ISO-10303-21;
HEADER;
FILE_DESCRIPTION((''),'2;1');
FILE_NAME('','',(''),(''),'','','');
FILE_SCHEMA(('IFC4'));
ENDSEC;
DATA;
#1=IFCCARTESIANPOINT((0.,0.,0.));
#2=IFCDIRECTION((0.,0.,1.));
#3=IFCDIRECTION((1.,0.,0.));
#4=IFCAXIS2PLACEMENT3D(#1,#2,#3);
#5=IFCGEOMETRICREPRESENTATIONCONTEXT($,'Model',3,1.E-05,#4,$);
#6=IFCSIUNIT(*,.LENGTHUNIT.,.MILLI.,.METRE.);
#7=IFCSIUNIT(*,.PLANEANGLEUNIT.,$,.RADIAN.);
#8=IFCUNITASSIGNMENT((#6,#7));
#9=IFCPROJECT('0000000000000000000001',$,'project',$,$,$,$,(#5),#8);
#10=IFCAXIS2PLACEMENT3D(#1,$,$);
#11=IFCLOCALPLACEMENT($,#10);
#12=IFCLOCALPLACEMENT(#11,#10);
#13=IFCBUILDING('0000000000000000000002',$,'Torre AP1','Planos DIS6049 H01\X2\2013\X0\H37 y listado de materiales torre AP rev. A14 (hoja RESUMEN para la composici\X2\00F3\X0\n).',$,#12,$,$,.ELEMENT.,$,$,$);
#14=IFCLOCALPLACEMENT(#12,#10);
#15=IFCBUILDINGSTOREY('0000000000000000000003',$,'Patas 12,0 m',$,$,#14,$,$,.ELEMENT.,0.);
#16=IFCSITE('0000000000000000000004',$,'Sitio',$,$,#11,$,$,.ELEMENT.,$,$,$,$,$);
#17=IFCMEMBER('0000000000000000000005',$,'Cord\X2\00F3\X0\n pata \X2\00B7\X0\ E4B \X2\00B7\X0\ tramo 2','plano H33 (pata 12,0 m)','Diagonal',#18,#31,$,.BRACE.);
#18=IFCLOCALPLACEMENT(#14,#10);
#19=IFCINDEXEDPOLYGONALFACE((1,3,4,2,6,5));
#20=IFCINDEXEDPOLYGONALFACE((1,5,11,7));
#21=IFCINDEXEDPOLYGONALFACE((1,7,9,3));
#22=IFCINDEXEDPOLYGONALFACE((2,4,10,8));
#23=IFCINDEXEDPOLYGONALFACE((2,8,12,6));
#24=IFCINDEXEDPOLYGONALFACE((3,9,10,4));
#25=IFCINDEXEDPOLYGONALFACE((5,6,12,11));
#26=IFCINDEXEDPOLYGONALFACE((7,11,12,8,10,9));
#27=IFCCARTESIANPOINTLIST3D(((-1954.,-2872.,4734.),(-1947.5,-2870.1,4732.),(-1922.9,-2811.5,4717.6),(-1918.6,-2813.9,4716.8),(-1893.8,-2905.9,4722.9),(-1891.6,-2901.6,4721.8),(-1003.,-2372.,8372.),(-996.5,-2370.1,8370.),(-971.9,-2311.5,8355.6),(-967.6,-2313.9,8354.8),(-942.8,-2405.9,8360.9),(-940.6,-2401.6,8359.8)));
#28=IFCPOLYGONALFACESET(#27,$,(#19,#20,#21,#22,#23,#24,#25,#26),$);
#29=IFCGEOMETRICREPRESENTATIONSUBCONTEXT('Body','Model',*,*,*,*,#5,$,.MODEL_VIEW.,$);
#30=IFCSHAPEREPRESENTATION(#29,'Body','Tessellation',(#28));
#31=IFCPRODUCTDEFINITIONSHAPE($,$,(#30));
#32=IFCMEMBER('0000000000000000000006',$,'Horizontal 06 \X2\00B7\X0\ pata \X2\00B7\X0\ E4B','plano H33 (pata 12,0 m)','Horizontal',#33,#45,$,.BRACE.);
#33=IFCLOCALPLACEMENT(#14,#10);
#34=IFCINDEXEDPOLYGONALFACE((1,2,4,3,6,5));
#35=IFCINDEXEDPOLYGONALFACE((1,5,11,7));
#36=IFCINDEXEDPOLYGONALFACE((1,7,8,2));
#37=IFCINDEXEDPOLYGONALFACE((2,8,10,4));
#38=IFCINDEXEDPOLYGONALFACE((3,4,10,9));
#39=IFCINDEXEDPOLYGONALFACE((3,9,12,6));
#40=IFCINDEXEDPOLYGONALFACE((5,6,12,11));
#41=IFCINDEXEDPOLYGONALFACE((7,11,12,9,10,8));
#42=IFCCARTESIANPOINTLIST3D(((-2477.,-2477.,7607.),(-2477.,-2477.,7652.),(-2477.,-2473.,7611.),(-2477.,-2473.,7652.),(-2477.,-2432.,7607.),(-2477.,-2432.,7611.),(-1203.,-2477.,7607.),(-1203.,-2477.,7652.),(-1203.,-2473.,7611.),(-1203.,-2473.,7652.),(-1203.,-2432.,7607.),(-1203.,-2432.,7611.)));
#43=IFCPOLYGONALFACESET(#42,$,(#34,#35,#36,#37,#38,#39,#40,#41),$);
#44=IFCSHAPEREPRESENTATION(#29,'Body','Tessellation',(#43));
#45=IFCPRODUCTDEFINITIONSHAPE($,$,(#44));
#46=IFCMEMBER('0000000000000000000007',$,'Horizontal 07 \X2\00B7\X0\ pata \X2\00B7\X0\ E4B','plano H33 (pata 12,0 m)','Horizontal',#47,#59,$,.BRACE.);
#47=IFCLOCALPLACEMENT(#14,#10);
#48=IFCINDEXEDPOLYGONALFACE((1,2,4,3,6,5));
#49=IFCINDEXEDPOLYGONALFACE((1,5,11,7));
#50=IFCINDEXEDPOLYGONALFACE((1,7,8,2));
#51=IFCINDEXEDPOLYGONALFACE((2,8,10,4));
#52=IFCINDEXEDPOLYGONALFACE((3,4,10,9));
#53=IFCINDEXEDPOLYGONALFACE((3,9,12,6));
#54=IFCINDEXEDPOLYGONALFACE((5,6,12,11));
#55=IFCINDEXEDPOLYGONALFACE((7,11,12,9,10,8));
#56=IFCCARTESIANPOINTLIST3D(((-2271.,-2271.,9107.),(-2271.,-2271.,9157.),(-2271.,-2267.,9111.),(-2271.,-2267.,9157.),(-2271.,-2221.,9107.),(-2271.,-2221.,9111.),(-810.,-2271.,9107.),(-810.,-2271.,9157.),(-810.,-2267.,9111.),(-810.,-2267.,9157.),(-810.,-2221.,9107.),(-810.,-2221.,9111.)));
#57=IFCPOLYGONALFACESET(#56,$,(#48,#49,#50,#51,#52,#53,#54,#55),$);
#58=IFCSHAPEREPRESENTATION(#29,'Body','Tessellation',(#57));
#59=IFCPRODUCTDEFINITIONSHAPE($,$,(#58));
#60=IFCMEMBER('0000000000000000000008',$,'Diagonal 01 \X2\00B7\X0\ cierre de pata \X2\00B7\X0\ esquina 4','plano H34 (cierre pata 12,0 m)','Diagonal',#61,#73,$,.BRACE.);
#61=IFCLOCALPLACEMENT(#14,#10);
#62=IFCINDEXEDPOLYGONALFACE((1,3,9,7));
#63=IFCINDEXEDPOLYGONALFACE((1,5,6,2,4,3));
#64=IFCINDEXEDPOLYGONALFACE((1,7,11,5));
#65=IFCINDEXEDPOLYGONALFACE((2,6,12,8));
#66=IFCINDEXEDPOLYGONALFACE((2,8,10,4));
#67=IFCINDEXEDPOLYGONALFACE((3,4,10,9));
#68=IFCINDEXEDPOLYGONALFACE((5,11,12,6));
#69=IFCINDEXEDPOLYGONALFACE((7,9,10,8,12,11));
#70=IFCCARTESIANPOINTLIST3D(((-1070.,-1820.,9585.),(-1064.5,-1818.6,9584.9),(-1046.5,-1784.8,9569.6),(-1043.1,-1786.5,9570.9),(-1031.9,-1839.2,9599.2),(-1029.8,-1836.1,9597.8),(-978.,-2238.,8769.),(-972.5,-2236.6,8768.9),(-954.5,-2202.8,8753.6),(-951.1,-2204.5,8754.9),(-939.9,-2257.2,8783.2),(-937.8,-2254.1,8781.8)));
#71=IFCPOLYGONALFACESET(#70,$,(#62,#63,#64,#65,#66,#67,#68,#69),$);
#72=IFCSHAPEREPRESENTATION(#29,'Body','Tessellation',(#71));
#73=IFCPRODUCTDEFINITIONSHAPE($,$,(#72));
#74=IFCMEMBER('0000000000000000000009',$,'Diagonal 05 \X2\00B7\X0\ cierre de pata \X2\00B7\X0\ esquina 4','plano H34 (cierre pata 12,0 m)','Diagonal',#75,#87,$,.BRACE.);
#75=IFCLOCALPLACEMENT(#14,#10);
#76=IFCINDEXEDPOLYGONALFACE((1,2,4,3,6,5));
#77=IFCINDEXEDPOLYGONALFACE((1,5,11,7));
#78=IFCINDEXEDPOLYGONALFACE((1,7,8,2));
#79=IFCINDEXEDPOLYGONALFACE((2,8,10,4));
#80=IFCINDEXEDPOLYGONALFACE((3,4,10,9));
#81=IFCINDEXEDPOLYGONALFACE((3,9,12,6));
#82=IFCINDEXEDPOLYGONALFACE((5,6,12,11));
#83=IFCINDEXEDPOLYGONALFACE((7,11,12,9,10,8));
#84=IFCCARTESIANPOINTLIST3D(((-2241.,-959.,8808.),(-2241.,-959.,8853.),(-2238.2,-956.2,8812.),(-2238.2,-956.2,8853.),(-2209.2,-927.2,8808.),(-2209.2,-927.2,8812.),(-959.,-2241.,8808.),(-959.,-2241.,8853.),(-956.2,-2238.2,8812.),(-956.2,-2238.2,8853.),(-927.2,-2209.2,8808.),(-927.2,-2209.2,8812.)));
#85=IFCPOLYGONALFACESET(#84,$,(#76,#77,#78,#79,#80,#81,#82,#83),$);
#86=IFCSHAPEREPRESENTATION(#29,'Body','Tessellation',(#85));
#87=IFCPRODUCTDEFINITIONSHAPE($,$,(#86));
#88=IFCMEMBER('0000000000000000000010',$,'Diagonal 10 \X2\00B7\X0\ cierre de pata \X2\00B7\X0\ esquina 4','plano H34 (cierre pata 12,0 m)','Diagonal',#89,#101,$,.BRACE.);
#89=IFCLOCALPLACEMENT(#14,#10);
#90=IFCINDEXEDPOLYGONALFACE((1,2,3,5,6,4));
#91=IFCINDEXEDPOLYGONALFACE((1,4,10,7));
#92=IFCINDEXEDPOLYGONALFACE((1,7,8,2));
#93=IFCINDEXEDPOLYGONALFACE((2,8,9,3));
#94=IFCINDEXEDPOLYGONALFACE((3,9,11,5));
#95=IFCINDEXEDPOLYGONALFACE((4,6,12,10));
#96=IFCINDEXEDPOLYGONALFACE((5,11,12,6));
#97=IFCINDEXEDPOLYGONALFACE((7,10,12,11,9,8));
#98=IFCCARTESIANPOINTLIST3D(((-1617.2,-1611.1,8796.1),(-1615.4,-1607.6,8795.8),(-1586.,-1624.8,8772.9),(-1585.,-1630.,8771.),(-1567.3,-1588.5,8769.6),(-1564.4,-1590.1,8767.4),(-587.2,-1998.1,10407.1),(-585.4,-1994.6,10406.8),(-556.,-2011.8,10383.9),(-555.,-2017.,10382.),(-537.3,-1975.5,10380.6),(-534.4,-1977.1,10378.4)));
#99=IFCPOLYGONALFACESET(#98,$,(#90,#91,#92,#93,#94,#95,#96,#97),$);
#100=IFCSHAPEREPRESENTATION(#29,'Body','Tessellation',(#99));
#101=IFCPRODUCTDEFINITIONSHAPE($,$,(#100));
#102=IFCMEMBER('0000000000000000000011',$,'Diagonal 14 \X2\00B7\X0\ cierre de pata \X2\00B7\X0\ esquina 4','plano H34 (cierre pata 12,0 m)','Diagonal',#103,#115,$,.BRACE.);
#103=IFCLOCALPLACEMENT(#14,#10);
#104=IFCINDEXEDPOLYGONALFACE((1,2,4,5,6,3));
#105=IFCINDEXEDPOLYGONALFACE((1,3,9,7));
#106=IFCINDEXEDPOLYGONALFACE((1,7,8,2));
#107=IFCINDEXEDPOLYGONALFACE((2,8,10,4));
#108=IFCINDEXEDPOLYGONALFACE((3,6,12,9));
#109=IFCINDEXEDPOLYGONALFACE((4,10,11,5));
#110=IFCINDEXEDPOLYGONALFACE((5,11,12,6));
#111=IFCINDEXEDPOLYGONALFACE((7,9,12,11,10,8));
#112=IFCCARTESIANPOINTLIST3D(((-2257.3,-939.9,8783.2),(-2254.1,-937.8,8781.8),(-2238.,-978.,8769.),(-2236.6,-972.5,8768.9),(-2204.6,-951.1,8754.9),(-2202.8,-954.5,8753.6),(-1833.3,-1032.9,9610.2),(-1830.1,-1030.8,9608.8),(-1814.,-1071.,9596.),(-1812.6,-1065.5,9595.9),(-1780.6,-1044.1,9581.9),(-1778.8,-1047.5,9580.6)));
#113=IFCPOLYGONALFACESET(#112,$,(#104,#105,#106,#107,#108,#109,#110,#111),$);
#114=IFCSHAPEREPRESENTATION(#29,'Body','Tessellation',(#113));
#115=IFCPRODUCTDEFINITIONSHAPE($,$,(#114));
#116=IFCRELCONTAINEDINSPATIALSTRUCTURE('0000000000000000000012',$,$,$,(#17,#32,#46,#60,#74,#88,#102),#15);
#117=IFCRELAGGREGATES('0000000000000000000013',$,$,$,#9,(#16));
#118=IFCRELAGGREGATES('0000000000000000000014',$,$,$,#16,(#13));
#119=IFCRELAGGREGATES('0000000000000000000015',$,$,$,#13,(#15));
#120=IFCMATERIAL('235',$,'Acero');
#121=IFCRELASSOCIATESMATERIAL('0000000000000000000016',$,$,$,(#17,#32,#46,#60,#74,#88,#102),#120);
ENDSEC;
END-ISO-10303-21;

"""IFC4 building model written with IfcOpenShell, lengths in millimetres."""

from ifc_helpers import new_model, si_unit, frame, frame_2d, origin, origin_with_axes, place, context, subcontext, project, spatial, l_section, extrude, material, element, save


model = new_model("IFC4")

# Units and contexts
model_context = context("Model", 3, precision=1e-05, world=origin_with_axes())
body_context = subcontext(model_context, "Body", "Model", "MODEL_VIEW")
ifc_project = project(units=[si_unit("LENGTHUNIT", "METRE", prefix="MILLI"), si_unit("PLANEANGLEUNIT", "RADIAN")], contexts=[model_context])

# Site, building, storey
site_placement = place(None, origin())
site = spatial("IfcSite", under=ifc_project, at=site_placement, Name="Sitio", CompositionType="ELEMENT")
building_placement = place(site_placement, origin())
building = spatial("IfcBuilding", under=site, at=building_placement, Name="Torre AP1", Description="Planos DIS6049 H01–H37 y listado de materiales torre AP rev. A14 (hoja RESUMEN para la composición).", CompositionType="ELEMENT")
storey_placement = place(building_placement, origin())
storey = spatial("IfcBuildingStorey", under=building, at=storey_placement, Name="Patas 12,0 m", CompositionType="ELEMENT", Elevation=0.0)

# Members
ifc_material_1 = material(Name="235", Category="Acero")
member_1_placement = place(storey_placement, frame((-1003.0, -2372.0, 8372.0), z_axis=(-0.250702, -0.13181, -0.959049), x_axis=(0.444282, 0.864528, -0.234958)))
element("IfcMember", 1, at=member_1_placement, inside=storey, material=ifc_material_1, Name="Cordón pata · E4B · tramo 2", Description="plano H33 (pata 12,0 m)", ObjectType="Diagonal", PredefinedType="BRACE", context=body_context, shape_type="SweptSolid", body=[
    extrude(l_section(Depth=70.0, Width=70.0, Thickness=5.0, at=frame_2d((35.0, 35.0))), None, (0.0, 0.0, 1.0), 3793.3),
])
member_2_placement = place(storey_placement, frame((-2477.0, -2477.0, 7607.0), z_axis=(1.0, 0.0, 0.0), x_axis=(0.0, 1.0, 0.0)))
element("IfcMember", 2, at=member_2_placement, inside=storey, material=ifc_material_1, Name="Horizontal 06 · pata · E4B", Description="plano H33 (pata 12,0 m)", ObjectType="Horizontal", PredefinedType="BRACE", context=body_context, shape_type="SweptSolid", body=[
    extrude(l_section(Depth=45.0, Width=45.0, Thickness=4.0, at=frame_2d((22.5, 22.5))), None, (0.0, 0.0, 1.0), 1274.0),
])
member_3_placement = place(storey_placement, frame((-2271.0, -2271.0, 9107.0), z_axis=(1.0, 0.0, 0.0), x_axis=(0.0, 1.0, 0.0)))
element("IfcMember", 3, at=member_3_placement, inside=storey, material=ifc_material_1, Name="Horizontal 07 · pata · E4B", Description="plano H33 (pata 12,0 m)", ObjectType="Horizontal", PredefinedType="BRACE", context=body_context, shape_type="SweptSolid", body=[
    extrude(l_section(Depth=50.0, Width=50.0, Thickness=4.0, at=frame_2d((25.0, 25.0))), None, (0.0, 0.0, 1.0), 1461.0),
])
member_4_placement = place(storey_placement, frame((-1070.0, -1820.0, 9585.0), z_axis=(0.099844, -0.45364, -0.885574), x_axis=(0.521462, 0.78186, -0.34172)))
element("IfcMember", 4, at=member_4_placement, inside=storey, material=ifc_material_1, Name="Diagonal 01 · cierre de pata · esquina 4", Description="plano H34 (cierre pata 12,0 m)", ObjectType="Diagonal", PredefinedType="BRACE", context=body_context, shape_type="SweptSolid", body=[
    extrude(l_section(Depth=45.0, Width=45.0, Thickness=4.0, at=frame_2d((22.5, 22.5))), None, (0.0, 0.0, 1.0), 921.4),
])
member_5_placement = place(storey_placement, frame((-2241.0, -959.0, 8808.0), z_axis=(0.707107, -0.707107, 0.0), x_axis=(0.707107, 0.707107, 0.0)))
element("IfcMember", 5, at=member_5_placement, inside=storey, material=ifc_material_1, Name="Diagonal 05 · cierre de pata · esquina 4", Description="plano H34 (cierre pata 12,0 m)", ObjectType="Diagonal", PredefinedType="BRACE", context=body_context, shape_type="SweptSolid", body=[
    extrude(l_section(Depth=45.0, Width=45.0, Thickness=4.0, at=frame_2d((22.5, 22.5))), None, (0.0, 0.0, 1.0), 1813.0),
])
member_6_placement = place(storey_placement, frame((-1585.0, -1630.0, 8771.0), z_axis=(0.527963, -0.198371, 0.825775), x_axis=(0.457467, 0.885645, -0.079731)))
element("IfcMember", 6, at=member_6_placement, inside=storey, material=ifc_material_1, Name="Diagonal 10 · cierre de pata · esquina 4", Description="plano H34 (cierre pata 12,0 m)", ObjectType="Diagonal", PredefinedType="BRACE", context=body_context, shape_type="SweptSolid", body=[
    extrude(l_section(Depth=45.0, Width=45.0, Thickness=4.0, at=frame_2d((22.5, 22.5))), None, (0.0, 0.0, 1.0), 1950.9),
])
member_7_placement = place(storey_placement, frame((-2238.0, -978.0, 8769.0), z_axis=(0.453962, -0.099572, 0.88544), x_axis=(0.781324, 0.522172, -0.341862)))
element("IfcMember", 7, at=member_7_placement, inside=storey, material=ifc_material_1, Name="Diagonal 14 · cierre de pata · esquina 4", Description="plano H34 (cierre pata 12,0 m)", ObjectType="Diagonal", PredefinedType="BRACE", context=body_context, shape_type="SweptSolid", body=[
    extrude(l_section(Depth=45.0, Width=45.0, Thickness=4.0, at=frame_2d((22.5, 22.5))), None, (0.0, 0.0, 1.0), 934.0),
])

save(model, "model.ifc")
